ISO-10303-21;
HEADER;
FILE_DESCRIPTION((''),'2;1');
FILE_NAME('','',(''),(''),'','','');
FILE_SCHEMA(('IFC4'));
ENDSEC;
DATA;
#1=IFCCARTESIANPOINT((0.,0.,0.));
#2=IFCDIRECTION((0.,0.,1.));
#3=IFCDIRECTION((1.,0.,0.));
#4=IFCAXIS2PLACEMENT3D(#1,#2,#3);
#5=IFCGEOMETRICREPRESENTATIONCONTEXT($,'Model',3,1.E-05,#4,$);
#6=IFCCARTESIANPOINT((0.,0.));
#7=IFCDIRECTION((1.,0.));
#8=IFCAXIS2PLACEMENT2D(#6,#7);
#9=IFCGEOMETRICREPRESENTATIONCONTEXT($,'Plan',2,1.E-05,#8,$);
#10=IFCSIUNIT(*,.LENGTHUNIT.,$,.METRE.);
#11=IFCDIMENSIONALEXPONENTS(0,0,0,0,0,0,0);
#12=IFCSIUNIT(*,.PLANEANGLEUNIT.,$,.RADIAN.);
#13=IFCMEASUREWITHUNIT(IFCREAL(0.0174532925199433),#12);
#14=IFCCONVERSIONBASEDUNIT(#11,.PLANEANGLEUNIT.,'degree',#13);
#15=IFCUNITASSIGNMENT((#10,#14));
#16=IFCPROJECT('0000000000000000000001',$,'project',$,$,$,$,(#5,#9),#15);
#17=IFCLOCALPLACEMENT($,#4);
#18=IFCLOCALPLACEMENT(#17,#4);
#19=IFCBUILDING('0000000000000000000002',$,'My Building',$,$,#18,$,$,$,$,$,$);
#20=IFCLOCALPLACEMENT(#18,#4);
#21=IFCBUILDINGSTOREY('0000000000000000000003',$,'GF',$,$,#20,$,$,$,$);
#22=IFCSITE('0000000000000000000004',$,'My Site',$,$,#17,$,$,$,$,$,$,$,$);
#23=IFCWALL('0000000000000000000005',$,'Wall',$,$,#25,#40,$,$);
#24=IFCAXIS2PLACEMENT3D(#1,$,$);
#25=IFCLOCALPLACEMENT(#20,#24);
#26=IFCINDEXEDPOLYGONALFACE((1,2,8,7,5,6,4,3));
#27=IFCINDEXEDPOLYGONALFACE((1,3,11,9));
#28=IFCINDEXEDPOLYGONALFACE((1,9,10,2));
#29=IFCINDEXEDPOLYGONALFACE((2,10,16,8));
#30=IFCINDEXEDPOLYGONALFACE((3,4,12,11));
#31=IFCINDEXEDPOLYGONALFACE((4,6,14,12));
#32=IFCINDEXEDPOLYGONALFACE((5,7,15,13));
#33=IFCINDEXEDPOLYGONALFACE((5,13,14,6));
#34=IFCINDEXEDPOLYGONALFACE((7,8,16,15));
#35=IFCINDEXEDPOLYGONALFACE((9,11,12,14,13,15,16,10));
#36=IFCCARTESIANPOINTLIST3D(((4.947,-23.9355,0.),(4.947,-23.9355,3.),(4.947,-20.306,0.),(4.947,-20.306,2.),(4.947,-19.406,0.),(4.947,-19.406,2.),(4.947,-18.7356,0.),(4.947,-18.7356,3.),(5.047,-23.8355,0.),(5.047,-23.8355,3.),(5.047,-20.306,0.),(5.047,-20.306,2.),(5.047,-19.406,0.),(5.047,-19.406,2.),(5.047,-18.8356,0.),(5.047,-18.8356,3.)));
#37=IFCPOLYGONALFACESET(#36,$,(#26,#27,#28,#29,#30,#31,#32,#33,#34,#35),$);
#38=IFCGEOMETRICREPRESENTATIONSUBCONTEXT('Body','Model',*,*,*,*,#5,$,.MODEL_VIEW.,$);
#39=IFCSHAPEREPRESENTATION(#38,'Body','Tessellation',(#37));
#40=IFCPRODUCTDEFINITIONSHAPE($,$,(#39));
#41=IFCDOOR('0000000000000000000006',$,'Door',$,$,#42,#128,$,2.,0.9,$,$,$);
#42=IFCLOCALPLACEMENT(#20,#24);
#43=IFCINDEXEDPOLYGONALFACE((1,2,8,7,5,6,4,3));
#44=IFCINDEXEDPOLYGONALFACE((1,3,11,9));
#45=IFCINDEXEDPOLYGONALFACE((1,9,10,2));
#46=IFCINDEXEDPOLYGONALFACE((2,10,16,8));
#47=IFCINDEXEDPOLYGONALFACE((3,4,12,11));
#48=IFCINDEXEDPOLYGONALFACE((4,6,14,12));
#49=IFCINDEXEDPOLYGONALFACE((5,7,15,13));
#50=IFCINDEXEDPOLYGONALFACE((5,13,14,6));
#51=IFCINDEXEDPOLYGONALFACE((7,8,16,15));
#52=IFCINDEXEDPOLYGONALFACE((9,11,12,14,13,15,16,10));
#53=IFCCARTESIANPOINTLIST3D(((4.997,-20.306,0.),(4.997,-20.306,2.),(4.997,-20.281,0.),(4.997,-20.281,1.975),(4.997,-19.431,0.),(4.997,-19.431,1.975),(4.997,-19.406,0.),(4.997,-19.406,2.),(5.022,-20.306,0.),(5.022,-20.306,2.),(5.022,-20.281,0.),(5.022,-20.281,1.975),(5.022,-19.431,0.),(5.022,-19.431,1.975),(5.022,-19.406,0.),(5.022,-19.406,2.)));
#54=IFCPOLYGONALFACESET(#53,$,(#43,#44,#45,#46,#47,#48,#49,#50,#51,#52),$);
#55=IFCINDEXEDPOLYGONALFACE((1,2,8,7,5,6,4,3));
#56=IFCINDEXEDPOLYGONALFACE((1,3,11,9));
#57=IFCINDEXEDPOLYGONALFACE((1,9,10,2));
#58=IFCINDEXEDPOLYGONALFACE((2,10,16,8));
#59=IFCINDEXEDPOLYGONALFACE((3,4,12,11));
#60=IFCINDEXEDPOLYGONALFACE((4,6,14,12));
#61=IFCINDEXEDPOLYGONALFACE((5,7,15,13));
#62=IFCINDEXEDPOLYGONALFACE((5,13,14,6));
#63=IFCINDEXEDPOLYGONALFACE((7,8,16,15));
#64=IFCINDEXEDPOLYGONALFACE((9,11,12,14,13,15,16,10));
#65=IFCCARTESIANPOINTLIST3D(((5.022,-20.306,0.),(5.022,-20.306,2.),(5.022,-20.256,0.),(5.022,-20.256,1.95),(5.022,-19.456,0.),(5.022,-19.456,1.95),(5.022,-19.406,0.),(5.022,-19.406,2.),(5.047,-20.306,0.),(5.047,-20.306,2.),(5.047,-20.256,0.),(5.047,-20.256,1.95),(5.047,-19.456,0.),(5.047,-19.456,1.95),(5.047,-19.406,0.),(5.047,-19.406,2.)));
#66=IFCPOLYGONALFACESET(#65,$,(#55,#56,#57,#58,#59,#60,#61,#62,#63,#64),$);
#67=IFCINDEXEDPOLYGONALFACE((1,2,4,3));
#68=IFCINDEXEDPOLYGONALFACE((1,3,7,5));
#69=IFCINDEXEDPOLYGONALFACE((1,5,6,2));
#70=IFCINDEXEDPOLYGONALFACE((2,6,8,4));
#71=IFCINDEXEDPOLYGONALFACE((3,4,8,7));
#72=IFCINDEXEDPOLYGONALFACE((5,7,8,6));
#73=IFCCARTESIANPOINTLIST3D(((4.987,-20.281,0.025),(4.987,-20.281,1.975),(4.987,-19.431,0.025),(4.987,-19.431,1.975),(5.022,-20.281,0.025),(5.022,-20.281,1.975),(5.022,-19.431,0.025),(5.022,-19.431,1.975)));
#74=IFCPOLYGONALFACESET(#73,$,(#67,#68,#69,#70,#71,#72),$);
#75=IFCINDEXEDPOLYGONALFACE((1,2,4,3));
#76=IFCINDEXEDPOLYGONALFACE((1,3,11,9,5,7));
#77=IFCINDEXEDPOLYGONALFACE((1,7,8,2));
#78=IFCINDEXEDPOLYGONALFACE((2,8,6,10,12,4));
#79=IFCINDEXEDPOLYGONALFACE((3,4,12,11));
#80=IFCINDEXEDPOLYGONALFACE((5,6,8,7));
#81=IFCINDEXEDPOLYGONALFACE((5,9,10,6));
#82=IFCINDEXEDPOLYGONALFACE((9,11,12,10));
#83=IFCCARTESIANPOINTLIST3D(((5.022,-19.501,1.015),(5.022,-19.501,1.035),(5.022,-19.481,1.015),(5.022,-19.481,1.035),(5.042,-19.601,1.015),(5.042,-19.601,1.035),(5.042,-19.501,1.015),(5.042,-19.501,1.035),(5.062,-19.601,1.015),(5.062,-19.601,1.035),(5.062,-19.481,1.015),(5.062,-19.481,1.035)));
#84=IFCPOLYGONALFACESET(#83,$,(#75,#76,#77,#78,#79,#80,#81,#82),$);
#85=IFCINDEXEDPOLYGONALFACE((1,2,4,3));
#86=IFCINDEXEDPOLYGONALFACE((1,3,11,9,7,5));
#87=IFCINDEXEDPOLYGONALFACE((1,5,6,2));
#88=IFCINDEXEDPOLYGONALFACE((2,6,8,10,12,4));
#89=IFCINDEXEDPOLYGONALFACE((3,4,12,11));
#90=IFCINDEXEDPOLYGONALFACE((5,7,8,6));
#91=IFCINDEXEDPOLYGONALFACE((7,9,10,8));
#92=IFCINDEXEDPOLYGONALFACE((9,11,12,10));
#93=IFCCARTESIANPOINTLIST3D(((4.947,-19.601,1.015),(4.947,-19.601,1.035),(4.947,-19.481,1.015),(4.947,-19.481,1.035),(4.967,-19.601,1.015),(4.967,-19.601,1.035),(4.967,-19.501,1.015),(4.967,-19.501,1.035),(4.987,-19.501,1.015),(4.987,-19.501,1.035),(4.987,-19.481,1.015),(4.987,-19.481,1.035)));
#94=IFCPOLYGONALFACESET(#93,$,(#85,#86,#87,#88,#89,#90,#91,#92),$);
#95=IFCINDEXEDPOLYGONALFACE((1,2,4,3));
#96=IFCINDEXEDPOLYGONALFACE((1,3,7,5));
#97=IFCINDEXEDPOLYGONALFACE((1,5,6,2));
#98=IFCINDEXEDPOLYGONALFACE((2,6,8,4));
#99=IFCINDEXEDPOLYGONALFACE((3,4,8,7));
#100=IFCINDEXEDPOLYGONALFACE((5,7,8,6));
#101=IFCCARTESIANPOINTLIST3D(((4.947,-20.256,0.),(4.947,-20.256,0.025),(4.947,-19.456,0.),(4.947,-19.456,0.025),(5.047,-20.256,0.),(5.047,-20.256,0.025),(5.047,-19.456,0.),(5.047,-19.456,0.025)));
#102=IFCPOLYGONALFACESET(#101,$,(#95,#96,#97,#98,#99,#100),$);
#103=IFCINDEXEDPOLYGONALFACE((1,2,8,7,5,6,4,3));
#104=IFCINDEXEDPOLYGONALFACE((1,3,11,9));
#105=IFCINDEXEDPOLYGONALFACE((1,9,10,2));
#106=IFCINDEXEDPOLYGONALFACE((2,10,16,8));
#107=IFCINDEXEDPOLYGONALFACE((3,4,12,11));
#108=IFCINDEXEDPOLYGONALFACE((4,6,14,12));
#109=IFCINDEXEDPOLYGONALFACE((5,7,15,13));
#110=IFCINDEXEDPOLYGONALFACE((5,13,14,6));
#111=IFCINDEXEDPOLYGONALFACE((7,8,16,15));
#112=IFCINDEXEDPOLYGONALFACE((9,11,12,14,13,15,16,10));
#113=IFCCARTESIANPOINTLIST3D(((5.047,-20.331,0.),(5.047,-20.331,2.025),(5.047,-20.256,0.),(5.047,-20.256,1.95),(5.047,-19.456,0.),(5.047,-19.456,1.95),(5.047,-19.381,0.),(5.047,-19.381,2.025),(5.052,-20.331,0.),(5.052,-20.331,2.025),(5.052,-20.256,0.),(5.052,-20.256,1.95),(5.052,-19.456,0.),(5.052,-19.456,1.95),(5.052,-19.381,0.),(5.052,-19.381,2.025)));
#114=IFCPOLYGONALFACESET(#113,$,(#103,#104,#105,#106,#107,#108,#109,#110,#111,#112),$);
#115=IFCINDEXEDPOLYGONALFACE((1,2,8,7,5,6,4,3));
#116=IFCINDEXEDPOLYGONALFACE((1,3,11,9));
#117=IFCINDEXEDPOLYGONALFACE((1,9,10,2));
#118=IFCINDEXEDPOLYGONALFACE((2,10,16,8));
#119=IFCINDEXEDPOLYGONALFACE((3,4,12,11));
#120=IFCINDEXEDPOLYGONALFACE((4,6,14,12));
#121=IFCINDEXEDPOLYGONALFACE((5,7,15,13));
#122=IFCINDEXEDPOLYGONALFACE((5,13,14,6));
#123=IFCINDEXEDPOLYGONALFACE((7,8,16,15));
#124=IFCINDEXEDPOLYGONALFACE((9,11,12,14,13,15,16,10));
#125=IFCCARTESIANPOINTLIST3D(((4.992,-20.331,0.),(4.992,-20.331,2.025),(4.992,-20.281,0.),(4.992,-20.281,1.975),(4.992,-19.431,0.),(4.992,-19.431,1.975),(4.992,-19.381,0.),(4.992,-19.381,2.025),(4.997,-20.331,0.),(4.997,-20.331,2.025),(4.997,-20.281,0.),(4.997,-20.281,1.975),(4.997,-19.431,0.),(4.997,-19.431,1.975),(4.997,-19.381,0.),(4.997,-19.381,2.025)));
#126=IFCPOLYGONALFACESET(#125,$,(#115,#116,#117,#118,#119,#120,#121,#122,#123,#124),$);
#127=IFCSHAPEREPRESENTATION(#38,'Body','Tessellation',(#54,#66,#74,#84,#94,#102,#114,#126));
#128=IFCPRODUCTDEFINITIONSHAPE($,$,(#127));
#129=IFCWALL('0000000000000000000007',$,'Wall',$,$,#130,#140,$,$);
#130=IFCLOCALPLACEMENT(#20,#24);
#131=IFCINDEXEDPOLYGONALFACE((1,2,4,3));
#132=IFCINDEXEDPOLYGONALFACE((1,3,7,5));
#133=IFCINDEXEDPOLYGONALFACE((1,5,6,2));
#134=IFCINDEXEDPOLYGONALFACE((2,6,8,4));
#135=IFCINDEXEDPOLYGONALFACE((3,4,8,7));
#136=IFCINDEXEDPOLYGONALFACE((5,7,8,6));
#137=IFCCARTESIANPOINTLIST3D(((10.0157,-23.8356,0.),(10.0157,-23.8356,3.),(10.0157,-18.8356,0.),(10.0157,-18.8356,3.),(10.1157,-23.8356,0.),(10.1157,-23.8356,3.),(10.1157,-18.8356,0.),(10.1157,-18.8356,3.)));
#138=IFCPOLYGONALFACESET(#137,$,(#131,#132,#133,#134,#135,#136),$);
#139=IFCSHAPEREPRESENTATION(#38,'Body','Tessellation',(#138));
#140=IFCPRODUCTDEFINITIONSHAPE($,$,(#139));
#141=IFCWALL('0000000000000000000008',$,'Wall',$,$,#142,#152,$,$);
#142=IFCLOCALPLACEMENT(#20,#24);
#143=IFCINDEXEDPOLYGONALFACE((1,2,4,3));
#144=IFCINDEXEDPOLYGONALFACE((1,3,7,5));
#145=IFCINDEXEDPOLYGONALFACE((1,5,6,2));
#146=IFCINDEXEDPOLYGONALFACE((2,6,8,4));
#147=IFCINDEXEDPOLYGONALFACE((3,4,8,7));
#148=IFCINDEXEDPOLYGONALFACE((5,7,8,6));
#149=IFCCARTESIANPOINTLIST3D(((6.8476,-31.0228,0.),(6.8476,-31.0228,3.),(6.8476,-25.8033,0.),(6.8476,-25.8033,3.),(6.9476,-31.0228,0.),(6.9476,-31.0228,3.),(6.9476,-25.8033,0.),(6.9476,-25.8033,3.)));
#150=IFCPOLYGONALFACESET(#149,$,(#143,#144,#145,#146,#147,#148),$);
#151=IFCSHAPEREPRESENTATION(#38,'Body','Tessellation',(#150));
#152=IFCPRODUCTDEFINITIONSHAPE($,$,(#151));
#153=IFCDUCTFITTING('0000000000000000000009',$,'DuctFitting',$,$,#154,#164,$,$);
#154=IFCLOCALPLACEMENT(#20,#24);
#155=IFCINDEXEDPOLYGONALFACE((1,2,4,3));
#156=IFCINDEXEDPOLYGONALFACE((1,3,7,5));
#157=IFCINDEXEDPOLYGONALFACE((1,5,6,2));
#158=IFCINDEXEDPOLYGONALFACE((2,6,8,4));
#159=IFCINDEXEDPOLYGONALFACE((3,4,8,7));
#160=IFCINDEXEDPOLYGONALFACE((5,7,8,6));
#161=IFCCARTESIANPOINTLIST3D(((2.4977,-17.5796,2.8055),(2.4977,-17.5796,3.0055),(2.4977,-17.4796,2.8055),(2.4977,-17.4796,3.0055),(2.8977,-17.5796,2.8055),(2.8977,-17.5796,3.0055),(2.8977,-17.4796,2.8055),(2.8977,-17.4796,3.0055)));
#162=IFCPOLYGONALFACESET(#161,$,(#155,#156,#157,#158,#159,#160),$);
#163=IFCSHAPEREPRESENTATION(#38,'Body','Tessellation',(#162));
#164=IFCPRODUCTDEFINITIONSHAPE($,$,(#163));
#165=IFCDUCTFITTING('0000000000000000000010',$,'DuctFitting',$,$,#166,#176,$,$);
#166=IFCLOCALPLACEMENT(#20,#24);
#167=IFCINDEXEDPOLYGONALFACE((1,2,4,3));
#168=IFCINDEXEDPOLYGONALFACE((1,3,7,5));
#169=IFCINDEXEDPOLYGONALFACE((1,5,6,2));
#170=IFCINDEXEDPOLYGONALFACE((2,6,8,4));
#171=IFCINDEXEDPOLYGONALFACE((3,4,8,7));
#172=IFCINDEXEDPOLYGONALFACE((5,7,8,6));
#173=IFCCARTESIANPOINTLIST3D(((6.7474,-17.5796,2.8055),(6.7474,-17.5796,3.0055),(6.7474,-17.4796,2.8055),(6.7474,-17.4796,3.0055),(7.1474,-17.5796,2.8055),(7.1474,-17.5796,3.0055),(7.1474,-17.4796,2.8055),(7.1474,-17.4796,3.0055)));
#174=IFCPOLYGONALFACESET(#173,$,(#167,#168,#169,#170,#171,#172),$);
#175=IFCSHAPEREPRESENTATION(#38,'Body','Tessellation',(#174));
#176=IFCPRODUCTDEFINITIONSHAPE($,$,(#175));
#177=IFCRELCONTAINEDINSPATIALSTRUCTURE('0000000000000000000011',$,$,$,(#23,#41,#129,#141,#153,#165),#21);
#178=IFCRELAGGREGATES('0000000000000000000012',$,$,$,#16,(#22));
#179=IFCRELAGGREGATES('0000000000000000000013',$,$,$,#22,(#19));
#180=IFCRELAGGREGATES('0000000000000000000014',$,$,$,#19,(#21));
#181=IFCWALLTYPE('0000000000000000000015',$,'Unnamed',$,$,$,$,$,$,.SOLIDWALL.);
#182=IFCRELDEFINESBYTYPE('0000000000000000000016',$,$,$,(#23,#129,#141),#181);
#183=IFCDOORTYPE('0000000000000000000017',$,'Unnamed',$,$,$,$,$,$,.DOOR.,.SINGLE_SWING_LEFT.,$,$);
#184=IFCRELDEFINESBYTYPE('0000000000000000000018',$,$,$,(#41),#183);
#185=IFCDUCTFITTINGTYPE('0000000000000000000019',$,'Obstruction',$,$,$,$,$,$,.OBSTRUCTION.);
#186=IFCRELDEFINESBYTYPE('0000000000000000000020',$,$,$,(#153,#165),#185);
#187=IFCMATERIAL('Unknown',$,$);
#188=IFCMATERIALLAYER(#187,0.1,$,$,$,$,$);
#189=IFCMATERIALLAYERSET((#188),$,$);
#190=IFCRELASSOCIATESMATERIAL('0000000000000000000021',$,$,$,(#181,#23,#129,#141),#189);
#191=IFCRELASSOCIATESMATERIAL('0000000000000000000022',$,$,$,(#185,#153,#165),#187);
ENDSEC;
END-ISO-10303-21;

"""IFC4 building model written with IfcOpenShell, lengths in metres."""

from ifc_helpers import new_model, entity, si_unit, converted_unit, frame, origin_with_axes, origin_2d_with_axis, place, context, subcontext, project, spatial, line, indexed_curve, rectangle, outline, extrude, shape, source, transform, mapped, material, layer, layer_set, layer_usage, material_profile, profile_set, profile_usage, type_object, type_shapes, element, fill, save


model = new_model("IFC4")

# Units and contexts
model_context = context("Model", 3, precision=1e-05, world=origin_with_axes())
plan_context = context("Plan", 2, precision=1e-05, world=origin_2d_with_axis())
body_context_1 = subcontext(model_context, "Body", "Model", "MODEL_VIEW")
body_context_2 = subcontext(plan_context, "Body", "Plan", "PLAN_VIEW")
ifc_project = project(units=[si_unit("LENGTHUNIT", "METRE"), converted_unit("PLANEANGLEUNIT", "degree", entity("IfcReal", 0.0174532925199433), si_unit("PLANEANGLEUNIT", "RADIAN"), dimensions=[0, 0, 0, 0, 0, 0, 0])], contexts=[model_context, plan_context])

# Site, building, storey
site_placement = place(None, origin_with_axes())
site = spatial("IfcSite", under=ifc_project, at=site_placement, Name="My Site")
building_placement = place(site_placement, origin_with_axes())
building = spatial("IfcBuilding", under=site, at=building_placement, Name="My Building")
storey_placement = place(building_placement, origin_with_axes())
storey = spatial("IfcBuildingStorey", under=building, at=storey_placement, Name="GF")

# Shared definitions
ifc_material = material(Name="Unknown")

# Shared definitions
ifc_layer_1 = layer(ifc_material, 0.1)
ifc_layer_set_1 = layer_set([ifc_layer_1])
wall_type = type_object("IfcWallType", Name="Unnamed", PredefinedType="SOLIDWALL", material=ifc_layer_set_1)

# Shared definitions
shared_shape_1 = source(origin_with_axes(), body_context_1, "Body", "SweptSolid", [
    extrude(outline(indexed_curve([(0.0, 0.0), (0.9, 0.0), (0.9, 2.0), (0.0, 2.0)], segments=[line(1, 2, 3, 4, 1)])), frame((0.0, -0.6, 0.0), z_axis=(0.0, -1.0, 0.0), x_axis=(1.0, 0.0, 0.0)), (0.0, 0.0, -1.0), 1.2),
])
door_type = type_object("IfcDoorType", Name="Unnamed", OperationType="SINGLE_SWING_LEFT", PredefinedType="DOOR")
shared_shape_2 = source(origin_with_axes(), body_context_1, "Body", "SweptSolid", [
    extrude(outline(indexed_curve([(0.0, 0.0), (0.0, 2.0), (0.9, 2.0), (0.9, 0.0), (0.875, 0.0), (0.875, 1.975), (0.025, 1.975), (0.025, 0.0)], segments=[line(1, 2, 3, 4, 5, 6, 7, 8, 1)])), frame((0.0, 0.025, 0.0), z_axis=(0.0, -1.0, 0.0), x_axis=(1.0, 0.0, 0.0)), (0.0, 0.0, -1.0), 0.025),
    extrude(outline(indexed_curve([(0.0, 0.0), (0.0, 2.0), (0.9, 2.0), (0.9, 0.0), (0.85, 0.0), (0.85, 1.95), (0.05, 1.95), (0.05, 0.0)], segments=[line(1, 2, 3, 4, 5, 6, 7, 8, 1)])), frame((0.0, 0.0, 0.0), z_axis=(0.0, -1.0, 0.0), x_axis=(1.0, 0.0, 0.0)), (0.0, 0.0, -1.0), 0.025),
    extrude(outline(indexed_curve([(0.0, 0.0), (0.85, 0.0), (0.85, 0.035), (0.0, 0.035)], segments=[line(1, 2, 3, 4, 1)])), frame((0.025, 0.025, 0.025), z_axis=(0.0, 0.0, 1.0), x_axis=(1.0, 0.0, 0.0)), (0.0, 0.0, 1.0), 1.95),
    extrude(outline(indexed_curve([(0.0, 0.0), (0.0, -0.04), (-0.12, -0.04), (-0.12, -0.02), (-0.02, -0.02), (-0.02, 0.0)], segments=[line(1, 2, 3, 4, 5, 6, 1)])), frame((0.825, 0.025, 1.015), z_axis=(0.0, 0.0, 1.0), x_axis=(1.0, 0.0, 0.0)), (0.0, 0.0, 1.0), 0.02),
    extrude(outline(indexed_curve([(0.0, 0.0), (0.0, 0.04), (-0.12, 0.04), (-0.12, 0.02), (-0.02, 0.02), (-0.02, 0.0)], segments=[line(1, 2, 3, 4, 5, 6, 1)])), frame((0.825, 0.06, 1.015), z_axis=(0.0, 0.0, 1.0), x_axis=(1.0, 0.0, 0.0)), (0.0, 0.0, 1.0), 0.02),
    extrude(outline(indexed_curve([(0.0, 0.0), (0.8, 0.0), (0.8, 0.1), (0.0, 0.1)], segments=[line(1, 2, 3, 4, 1)])), frame((0.05, 0.0, 0.0), z_axis=(0.0, 0.0, 1.0), x_axis=(1.0, 0.0, 0.0)), (0.0, 0.0, 1.0), 0.025),
    extrude(outline(indexed_curve([(0.0, 0.0), (0.0, 2.025), (0.95, 2.025), (0.95, 0.0), (0.875, 0.0), (0.875, 1.95), (0.075, 1.95), (0.075, 0.0)], segments=[line(1, 2, 3, 4, 5, 6, 7, 8, 1)])), frame((-0.025, -0.005, 0.0), z_axis=(0.0, -1.0, 0.0), x_axis=(1.0, 0.0, 0.0)), (0.0, 0.0, -1.0), 0.005),
    extrude(outline(indexed_curve([(0.0, 0.0), (0.0, 2.025), (0.95, 2.025), (0.95, 0.0), (0.9, 0.0), (0.9, 1.975), (0.05, 1.975), (0.05, 0.0)], segments=[line(1, 2, 3, 4, 5, 6, 7, 8, 1)])), frame((-0.025, 0.05, 0.0), z_axis=(0.0, -1.0, 0.0), x_axis=(1.0, 0.0, 0.0)), (0.0, 0.0, -1.0), 0.005),
])
shared_shape_3 = source(origin_with_axes(), body_context_2, "Body", "Curve2D", [
    entity("IfcIndexedPolyCurve", entity("IfcCartesianPointList2D", [[0.0, 0.0], [0.0, 0.05], [0.025, 0.05], [0.025, 0.025], [0.05, 0.025], [0.05, 0.0]]), [entity("IfcLineIndex", [1, 2, 3, 4, 5, 6, 1])]),
    entity("IfcIndexedPolyCurve", entity("IfcCartesianPointList2D", [[0.9, 0.0], [0.9, 0.05], [0.875, 0.05], [0.875, 0.025], [0.85, 0.025], [0.85, 0.0]]), [entity("IfcLineIndex", [1, 2, 3, 4, 5, 6, 1])]),
    entity("IfcTrimmedCurve", entity("IfcEllipse", entity("IfcAxis2Placement2D", entity("IfcCartesianPoint", [0.06, 0.05]), entity("IfcDirection", [1.0, 0.0])), 0.815, 0.85), [entity("IfcCartesianPoint", [0.875, 0.05])], [entity("IfcCartesianPoint", [0.06, 0.9])], True, "CARTESIAN"),
    entity("IfcIndexedPolyCurve", entity("IfcCartesianPointList2D", [[0.025, 0.05], [0.06, 0.05], [0.06, 0.9], [0.025, 0.9]]), [entity("IfcLineIndex", [1, 2, 3, 4, 1])]),
])
type_shapes(door_type, [shared_shape_2, shared_shape_3])

# Wall, opening, door
ifc_layer_usage_1 = layer_usage(ifc_layer_set_1, "AXIS2", "POSITIVE", 0.0)
wall_1_placement = place(storey_placement, frame((5.047, -23.8355, 0.0), z_axis=(0.0, 0.0, 1.0), x_axis=(0.0, 1.0, 0.0)))
wall_1 = element("IfcWall", 1, at=wall_1_placement, inside=storey, type_object=wall_type, material=ifc_layer_usage_1, Name="Wall", context=body_context_1, shape_type="SweptSolid", body=[
    extrude(outline(indexed_curve([(0.0, 0.0), (-0.1, 0.1), (5.1, 0.1), (5.0, 0.0)], segments=[line(1, 2, 3, 4, 1)])), origin_with_axes(), (0.0, 0.0, 1.0), 3.0),
])
opening_1_placement = place(wall_1_placement, frame((3.5295, 0.0, 0.0), z_axis=(0.0, 0.0, 1.0), x_axis=(1.0, 0.0, 0.0)))
opening_1 = element("IfcOpeningElement", 2, at=opening_1_placement, cuts=wall_1, PredefinedType="OPENING", context=body_context_1, shape_type="MappedRepresentation", body=[
    mapped(shared_shape_1, transform((0.0, 0.0, 0.0), x_axis=(1.0, 0.0, 0.0), y_axis=(0.0, 1.0, 0.0), z_axis=(0.0, 0.0, 1.0), scale=1.0)),
])
door_1_placement = place(opening_1_placement, frame((0.0, 0.0, 0.0), z_axis=(0.0, 0.0, 1.0), x_axis=(1.0, 0.0, 0.0)))
door_1 = element("IfcDoor", 3, at=door_1_placement, inside=storey, type_object=door_type, Name="Door", OverallHeight=2.0, OverallWidth=0.9, shapes=[
    shape(body_context_1, "Body", "MappedRepresentation", [mapped(shared_shape_2, transform((0.0, 0.0, 0.0), x_axis=(1.0, 0.0, 0.0), y_axis=(0.0, 1.0, 0.0), z_axis=(0.0, 0.0, 1.0), scale=1.0))]),
    shape(body_context_2, "Body", "MappedRepresentation", [mapped(shared_shape_3, transform((0.0, 0.0, 0.0), x_axis=(1.0, 0.0, 0.0), y_axis=(0.0, 1.0, 0.0), z_axis=(0.0, 0.0, 1.0), scale=1.0))]),
])
fill(opening_1, door_1)

# Walls
ifc_layer_usage_2 = layer_usage(ifc_layer_set_1, "AXIS2", "POSITIVE", 0.0)
wall_2_placement = place(storey_placement, frame((10.0157, -18.8356, 0.0), z_axis=(0.0, 0.0, 1.0), x_axis=(0.0, -1.0, 0.0)))
element("IfcWall", 4, at=wall_2_placement, inside=storey, type_object=wall_type, material=ifc_layer_usage_2, Name="Wall", context=body_context_1, shape_type="SweptSolid", body=[
    extrude(outline(indexed_curve([(0.0, 0.0), (0.0, 0.1), (5.0, 0.1), (5.0, 0.0)], segments=[line(1, 2, 3, 4, 1)])), origin_with_axes(), (0.0, 0.0, 1.0), 3.0),
])
ifc_layer_usage_3 = layer_usage(ifc_layer_set_1, "AXIS2", "POSITIVE", 0.0)
wall_3_placement = place(storey_placement, frame((6.8476, -25.8033, 0.0), z_axis=(0.0, 0.0, 1.0), x_axis=(0.0, -1.0, 0.0)))
element("IfcWall", 5, at=wall_3_placement, inside=storey, type_object=wall_type, material=ifc_layer_usage_3, Name="Wall", context=body_context_1, shape_type="SweptSolid", body=[
    extrude(outline(indexed_curve([(0.0, 0.0), (0.0, 0.1), (5.2195, 0.1), (5.2195, 0.0)], segments=[line(1, 2, 3, 4, 1)])), origin_with_axes(), (0.0, 0.0, 1.0), 3.0),
])

# Duct fittings
ifc_material_profile = material_profile(ifc_material, rectangle(XDim=0.4, YDim=0.2))
ifc_profile_set = profile_set([ifc_material_profile])
ifc_profile_usage_1 = profile_usage(ifc_profile_set, cardinal=5)
duct_fitting_type = type_object("IfcDuctFittingType", Name="Obstruction", PredefinedType="OBSTRUCTION", material=ifc_profile_set)
duct_fitting_1_placement = place(storey_placement, frame((2.6977, -17.5796, 2.9055), z_axis=(0.0, 1.0, 0.0), x_axis=(-1.0, 0.0, 0.0)))
element("IfcDuctFitting", 6, at=duct_fitting_1_placement, inside=storey, type_object=duct_fitting_type, material=ifc_profile_usage_1, Name="DuctFitting", context=body_context_1, shape_type="SweptSolid", body=[
    extrude(rectangle(XDim=0.4, YDim=0.2), origin_with_axes(), (0.0, 0.0, 1.0), 0.1),
])
ifc_profile_usage_2 = profile_usage(ifc_profile_set, cardinal=5)
duct_fitting_2_placement = place(storey_placement, frame((6.9474, -17.5796, 2.9055), z_axis=(0.0, 1.0, 0.0), x_axis=(-1.0, 0.0, 0.0)))
element("IfcDuctFitting", 7, at=duct_fitting_2_placement, inside=storey, type_object=duct_fitting_type, material=ifc_profile_usage_2, Name="DuctFitting", context=body_context_1, shape_type="SweptSolid", body=[
    extrude(rectangle(XDim=0.4, YDim=0.2), origin_with_axes(), (0.0, 0.0, 1.0), 0.1),
])

save(model, "model.ifc")
